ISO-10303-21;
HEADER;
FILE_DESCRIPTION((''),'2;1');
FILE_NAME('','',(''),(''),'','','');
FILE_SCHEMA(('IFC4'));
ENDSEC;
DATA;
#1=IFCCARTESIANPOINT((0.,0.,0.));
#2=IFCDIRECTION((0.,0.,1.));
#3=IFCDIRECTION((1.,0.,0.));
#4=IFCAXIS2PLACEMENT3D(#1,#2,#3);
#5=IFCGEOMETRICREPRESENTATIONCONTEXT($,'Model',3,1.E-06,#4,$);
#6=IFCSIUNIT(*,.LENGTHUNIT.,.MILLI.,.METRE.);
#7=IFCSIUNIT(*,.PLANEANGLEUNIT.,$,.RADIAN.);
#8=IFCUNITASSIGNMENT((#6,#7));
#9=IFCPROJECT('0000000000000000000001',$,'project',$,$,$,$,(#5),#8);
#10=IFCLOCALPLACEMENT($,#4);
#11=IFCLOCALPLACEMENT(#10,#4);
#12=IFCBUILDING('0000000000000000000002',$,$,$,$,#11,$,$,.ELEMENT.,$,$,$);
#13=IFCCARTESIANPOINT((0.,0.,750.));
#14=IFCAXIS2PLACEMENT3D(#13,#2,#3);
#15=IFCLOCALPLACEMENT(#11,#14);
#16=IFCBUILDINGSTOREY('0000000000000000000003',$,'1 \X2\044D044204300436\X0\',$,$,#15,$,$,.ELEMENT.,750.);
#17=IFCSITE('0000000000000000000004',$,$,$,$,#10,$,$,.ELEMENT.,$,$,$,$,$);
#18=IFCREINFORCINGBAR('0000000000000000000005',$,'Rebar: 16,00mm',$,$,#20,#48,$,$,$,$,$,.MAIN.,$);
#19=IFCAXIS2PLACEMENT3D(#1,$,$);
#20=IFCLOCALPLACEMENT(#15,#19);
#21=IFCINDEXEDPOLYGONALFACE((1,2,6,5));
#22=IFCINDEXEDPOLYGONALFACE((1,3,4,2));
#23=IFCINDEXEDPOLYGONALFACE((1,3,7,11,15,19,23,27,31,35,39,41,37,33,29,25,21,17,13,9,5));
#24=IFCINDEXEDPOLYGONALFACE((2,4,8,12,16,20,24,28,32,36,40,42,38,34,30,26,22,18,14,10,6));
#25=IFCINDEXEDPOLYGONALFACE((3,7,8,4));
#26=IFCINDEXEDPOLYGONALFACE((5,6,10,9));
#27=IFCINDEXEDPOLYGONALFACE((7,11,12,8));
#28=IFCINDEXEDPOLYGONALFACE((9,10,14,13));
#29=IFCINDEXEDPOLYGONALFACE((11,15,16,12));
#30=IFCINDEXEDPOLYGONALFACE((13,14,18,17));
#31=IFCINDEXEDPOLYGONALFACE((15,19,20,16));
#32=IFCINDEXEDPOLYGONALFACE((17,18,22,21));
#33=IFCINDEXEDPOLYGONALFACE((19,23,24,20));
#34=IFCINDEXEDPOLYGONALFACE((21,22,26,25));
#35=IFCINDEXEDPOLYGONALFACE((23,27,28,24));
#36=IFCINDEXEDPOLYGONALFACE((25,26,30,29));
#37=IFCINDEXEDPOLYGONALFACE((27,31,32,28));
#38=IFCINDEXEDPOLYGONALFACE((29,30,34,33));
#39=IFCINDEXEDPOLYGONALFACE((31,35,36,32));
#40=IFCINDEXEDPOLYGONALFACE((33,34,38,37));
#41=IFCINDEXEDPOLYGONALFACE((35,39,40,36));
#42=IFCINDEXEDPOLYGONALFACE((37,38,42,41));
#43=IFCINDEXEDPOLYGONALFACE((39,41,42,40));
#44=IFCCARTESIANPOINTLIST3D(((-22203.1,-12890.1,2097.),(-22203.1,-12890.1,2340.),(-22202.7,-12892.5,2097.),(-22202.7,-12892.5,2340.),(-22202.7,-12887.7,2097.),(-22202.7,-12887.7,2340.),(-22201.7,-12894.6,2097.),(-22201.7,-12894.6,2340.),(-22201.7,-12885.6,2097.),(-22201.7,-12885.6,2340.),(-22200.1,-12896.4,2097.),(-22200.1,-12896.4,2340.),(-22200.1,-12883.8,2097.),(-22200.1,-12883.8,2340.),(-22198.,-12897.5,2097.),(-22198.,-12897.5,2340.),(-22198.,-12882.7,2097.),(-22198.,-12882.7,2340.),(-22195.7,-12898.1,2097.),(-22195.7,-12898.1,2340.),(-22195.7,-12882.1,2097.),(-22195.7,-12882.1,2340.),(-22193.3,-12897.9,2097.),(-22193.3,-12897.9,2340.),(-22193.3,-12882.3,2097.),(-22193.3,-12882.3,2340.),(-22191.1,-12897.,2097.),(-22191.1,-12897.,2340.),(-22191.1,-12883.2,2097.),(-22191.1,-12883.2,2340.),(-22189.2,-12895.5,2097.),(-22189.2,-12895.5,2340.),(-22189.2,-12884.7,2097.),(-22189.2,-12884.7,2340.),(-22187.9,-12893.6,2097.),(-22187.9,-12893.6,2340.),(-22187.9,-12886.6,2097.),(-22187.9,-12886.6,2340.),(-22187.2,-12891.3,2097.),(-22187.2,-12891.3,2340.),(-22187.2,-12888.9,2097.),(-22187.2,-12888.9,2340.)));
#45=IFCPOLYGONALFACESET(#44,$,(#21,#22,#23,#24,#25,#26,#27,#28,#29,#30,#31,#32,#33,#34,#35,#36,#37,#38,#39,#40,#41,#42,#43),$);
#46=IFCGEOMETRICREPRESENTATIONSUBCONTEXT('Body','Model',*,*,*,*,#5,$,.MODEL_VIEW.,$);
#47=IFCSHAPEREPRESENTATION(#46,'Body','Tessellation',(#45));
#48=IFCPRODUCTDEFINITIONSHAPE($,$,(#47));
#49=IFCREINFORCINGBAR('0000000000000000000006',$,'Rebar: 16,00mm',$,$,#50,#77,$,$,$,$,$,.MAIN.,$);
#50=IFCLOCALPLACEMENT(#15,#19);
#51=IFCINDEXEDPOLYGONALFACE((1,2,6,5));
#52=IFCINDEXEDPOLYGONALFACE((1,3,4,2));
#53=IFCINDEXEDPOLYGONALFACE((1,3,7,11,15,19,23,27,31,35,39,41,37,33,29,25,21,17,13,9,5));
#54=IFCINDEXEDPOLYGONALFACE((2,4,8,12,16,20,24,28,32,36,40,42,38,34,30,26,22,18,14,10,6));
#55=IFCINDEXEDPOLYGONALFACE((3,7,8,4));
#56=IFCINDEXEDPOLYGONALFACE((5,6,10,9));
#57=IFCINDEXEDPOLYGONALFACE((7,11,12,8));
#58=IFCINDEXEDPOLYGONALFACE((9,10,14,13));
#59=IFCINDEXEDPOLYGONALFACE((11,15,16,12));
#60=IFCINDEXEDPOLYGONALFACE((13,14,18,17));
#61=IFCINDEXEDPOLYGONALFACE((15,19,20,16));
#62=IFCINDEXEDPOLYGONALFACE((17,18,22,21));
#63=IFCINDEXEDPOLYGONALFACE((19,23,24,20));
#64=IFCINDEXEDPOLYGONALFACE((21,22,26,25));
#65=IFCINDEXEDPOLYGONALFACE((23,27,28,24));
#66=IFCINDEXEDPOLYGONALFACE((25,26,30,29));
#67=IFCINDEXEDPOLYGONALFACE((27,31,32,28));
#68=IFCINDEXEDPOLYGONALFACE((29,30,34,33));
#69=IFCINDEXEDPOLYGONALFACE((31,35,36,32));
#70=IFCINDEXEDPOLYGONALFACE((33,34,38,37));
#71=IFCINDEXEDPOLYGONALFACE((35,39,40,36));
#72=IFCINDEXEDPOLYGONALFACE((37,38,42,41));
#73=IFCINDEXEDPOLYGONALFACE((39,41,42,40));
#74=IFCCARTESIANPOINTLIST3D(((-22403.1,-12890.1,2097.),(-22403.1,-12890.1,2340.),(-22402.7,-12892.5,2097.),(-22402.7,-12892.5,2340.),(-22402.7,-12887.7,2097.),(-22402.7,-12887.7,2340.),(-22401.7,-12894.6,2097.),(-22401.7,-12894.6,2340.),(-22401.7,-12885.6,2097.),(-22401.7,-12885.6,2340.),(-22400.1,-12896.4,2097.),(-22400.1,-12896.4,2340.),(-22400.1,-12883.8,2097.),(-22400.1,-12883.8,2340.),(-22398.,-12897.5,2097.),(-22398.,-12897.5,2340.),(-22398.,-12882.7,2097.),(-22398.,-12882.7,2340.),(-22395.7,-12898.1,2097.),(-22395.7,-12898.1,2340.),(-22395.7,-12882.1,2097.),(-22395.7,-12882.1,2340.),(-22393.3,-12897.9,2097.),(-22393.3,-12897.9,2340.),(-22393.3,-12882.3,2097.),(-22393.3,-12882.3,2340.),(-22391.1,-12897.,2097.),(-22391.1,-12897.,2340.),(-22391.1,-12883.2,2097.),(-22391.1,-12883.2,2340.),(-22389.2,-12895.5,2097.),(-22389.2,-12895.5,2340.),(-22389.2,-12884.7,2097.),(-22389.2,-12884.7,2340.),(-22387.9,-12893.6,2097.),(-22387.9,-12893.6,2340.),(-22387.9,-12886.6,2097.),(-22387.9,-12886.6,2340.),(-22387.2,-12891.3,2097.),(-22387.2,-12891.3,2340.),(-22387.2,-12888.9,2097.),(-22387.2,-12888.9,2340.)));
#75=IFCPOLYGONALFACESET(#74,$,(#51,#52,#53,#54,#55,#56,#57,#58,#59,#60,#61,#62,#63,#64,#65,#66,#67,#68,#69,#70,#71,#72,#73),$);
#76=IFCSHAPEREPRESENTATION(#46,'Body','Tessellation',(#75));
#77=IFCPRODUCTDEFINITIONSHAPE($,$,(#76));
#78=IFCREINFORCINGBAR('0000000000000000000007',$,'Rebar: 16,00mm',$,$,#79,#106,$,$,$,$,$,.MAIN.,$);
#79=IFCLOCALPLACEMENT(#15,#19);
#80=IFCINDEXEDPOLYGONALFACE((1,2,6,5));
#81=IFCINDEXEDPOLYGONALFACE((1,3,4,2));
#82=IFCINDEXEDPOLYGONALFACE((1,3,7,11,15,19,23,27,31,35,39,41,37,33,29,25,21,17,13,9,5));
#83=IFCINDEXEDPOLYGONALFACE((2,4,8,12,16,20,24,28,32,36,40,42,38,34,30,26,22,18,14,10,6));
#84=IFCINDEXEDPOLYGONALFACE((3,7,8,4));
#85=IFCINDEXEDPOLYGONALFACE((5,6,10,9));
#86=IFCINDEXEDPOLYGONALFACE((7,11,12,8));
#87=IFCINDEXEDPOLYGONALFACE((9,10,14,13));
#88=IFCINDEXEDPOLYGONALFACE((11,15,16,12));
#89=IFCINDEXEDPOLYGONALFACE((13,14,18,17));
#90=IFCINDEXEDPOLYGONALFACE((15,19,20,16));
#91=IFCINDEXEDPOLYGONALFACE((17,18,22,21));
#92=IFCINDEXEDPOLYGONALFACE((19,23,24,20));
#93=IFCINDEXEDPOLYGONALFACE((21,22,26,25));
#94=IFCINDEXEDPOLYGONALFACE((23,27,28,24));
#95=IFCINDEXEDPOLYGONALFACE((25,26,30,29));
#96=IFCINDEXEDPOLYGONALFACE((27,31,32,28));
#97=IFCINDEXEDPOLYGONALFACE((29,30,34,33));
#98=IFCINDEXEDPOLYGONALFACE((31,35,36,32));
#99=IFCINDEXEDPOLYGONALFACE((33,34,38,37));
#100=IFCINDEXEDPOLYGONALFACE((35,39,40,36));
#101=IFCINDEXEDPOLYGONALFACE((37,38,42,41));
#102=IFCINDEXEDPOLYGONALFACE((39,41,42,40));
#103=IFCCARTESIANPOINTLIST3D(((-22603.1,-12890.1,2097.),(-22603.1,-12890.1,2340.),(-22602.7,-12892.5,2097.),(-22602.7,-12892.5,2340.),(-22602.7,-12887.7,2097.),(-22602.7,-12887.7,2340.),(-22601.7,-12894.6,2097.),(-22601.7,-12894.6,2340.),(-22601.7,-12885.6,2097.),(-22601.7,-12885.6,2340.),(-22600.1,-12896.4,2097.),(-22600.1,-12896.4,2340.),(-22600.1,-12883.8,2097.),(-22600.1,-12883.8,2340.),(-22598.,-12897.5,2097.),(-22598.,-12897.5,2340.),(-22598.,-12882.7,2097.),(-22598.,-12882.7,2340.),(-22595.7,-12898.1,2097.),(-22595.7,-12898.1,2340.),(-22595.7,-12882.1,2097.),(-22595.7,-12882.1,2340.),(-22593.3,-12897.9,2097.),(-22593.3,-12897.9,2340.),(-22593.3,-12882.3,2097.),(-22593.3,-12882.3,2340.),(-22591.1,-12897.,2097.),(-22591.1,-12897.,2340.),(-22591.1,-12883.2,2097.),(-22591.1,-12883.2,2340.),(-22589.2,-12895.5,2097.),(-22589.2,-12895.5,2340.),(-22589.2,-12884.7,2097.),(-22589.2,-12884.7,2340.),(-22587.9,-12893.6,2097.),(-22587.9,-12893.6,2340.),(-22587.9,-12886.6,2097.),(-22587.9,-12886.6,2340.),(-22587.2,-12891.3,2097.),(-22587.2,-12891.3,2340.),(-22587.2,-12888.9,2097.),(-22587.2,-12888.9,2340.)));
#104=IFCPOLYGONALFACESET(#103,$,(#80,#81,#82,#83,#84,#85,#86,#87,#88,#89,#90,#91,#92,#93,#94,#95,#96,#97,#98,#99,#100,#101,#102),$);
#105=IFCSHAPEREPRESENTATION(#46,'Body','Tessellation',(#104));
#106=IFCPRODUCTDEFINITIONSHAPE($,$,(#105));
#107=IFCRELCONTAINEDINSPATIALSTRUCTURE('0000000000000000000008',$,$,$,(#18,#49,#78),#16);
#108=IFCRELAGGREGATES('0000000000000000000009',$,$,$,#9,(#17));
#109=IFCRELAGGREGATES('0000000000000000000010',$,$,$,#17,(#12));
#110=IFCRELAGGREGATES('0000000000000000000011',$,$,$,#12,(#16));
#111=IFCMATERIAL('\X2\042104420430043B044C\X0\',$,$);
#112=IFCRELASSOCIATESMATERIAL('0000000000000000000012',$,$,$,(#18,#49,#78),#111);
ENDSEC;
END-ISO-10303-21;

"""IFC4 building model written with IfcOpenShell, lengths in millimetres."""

from ifc_helpers import new_model, entity, si_unit, frame, origin_with_axes, place, context, subcontext, project, spatial, source, transform, mapped, material, element, save


model = new_model("IFC4")

# Units and contexts
model_context = context("Model", 3, precision=1e-06, world=origin_with_axes())
body_context = subcontext(model_context, "Body", "Model", "MODEL_VIEW")
ifc_project = project(units=[si_unit("LENGTHUNIT", "METRE", prefix="MILLI"), si_unit("PLANEANGLEUNIT", "RADIAN")], contexts=[model_context])

# Site, building, storey
site_placement = place(None, origin_with_axes())
site = spatial("IfcSite", under=ifc_project, at=site_placement, CompositionType="ELEMENT")
building_placement = place(site_placement, origin_with_axes())
building = spatial("IfcBuilding", under=site, at=building_placement, CompositionType="ELEMENT")
storey_placement = place(building_placement, frame((0.0, 0.0, 750.0), z_axis=(0.0, 0.0, 1.0), x_axis=(1.0, 0.0, 0.0)))
storey = spatial("IfcBuildingStorey", under=building, at=storey_placement, Name="1 этаж", CompositionType="ELEMENT", Elevation=750.0)

# Reinforcing bars
ifc_material = material(Name="Сталь")
shared_shape_1 = source(origin_with_axes(), body_context, "Body", "AdvancedSweptSolid", [
    entity("IfcSweptDiskSolid", entity("IfcIndexedPolyCurve", entity("IfcCartesianPointList3D", [[0.0, 0.0, 0.0], [243.0, 0.0, 0.0]]), [entity("IfcLineIndex", [1, 2])]), 8.0),
])
reinforcing_bar_1_placement = place(storey_placement, origin_with_axes())
element("IfcReinforcingBar", 1, at=reinforcing_bar_1_placement, inside=storey, material=ifc_material, Name="Rebar: 16,00mm", PredefinedType="MAIN", context=body_context, shape_type="MappedRepresentation", body=[
    mapped(shared_shape_1, transform((-22195.1, -12890.1, 2097.0), x_axis=(0.0, 0.0, 1.0), y_axis=(0.0, 1.0, 0.0), z_axis=(-1.0, 0.0, 0.0), scale=1.0)),
])
reinforcing_bar_2_placement = place(storey_placement, origin_with_axes())
element("IfcReinforcingBar", 2, at=reinforcing_bar_2_placement, inside=storey, material=ifc_material, Name="Rebar: 16,00mm", PredefinedType="MAIN", context=body_context, shape_type="MappedRepresentation", body=[
    mapped(shared_shape_1, transform((-22395.1, -12890.1, 2097.0), x_axis=(0.0, 0.0, 1.0), y_axis=(0.0, 1.0, 0.0), z_axis=(-1.0, 0.0, 0.0), scale=1.0)),
])
reinforcing_bar_3_placement = place(storey_placement, origin_with_axes())
element("IfcReinforcingBar", 3, at=reinforcing_bar_3_placement, inside=storey, material=ifc_material, Name="Rebar: 16,00mm", PredefinedType="MAIN", context=body_context, shape_type="MappedRepresentation", body=[
    mapped(shared_shape_1, transform((-22595.1, -12890.1, 2097.0), x_axis=(0.0, 0.0, 1.0), y_axis=(0.0, 1.0, 0.0), z_axis=(-1.0, 0.0, 0.0), scale=1.0)),
])

save(model, "model.ifc")
